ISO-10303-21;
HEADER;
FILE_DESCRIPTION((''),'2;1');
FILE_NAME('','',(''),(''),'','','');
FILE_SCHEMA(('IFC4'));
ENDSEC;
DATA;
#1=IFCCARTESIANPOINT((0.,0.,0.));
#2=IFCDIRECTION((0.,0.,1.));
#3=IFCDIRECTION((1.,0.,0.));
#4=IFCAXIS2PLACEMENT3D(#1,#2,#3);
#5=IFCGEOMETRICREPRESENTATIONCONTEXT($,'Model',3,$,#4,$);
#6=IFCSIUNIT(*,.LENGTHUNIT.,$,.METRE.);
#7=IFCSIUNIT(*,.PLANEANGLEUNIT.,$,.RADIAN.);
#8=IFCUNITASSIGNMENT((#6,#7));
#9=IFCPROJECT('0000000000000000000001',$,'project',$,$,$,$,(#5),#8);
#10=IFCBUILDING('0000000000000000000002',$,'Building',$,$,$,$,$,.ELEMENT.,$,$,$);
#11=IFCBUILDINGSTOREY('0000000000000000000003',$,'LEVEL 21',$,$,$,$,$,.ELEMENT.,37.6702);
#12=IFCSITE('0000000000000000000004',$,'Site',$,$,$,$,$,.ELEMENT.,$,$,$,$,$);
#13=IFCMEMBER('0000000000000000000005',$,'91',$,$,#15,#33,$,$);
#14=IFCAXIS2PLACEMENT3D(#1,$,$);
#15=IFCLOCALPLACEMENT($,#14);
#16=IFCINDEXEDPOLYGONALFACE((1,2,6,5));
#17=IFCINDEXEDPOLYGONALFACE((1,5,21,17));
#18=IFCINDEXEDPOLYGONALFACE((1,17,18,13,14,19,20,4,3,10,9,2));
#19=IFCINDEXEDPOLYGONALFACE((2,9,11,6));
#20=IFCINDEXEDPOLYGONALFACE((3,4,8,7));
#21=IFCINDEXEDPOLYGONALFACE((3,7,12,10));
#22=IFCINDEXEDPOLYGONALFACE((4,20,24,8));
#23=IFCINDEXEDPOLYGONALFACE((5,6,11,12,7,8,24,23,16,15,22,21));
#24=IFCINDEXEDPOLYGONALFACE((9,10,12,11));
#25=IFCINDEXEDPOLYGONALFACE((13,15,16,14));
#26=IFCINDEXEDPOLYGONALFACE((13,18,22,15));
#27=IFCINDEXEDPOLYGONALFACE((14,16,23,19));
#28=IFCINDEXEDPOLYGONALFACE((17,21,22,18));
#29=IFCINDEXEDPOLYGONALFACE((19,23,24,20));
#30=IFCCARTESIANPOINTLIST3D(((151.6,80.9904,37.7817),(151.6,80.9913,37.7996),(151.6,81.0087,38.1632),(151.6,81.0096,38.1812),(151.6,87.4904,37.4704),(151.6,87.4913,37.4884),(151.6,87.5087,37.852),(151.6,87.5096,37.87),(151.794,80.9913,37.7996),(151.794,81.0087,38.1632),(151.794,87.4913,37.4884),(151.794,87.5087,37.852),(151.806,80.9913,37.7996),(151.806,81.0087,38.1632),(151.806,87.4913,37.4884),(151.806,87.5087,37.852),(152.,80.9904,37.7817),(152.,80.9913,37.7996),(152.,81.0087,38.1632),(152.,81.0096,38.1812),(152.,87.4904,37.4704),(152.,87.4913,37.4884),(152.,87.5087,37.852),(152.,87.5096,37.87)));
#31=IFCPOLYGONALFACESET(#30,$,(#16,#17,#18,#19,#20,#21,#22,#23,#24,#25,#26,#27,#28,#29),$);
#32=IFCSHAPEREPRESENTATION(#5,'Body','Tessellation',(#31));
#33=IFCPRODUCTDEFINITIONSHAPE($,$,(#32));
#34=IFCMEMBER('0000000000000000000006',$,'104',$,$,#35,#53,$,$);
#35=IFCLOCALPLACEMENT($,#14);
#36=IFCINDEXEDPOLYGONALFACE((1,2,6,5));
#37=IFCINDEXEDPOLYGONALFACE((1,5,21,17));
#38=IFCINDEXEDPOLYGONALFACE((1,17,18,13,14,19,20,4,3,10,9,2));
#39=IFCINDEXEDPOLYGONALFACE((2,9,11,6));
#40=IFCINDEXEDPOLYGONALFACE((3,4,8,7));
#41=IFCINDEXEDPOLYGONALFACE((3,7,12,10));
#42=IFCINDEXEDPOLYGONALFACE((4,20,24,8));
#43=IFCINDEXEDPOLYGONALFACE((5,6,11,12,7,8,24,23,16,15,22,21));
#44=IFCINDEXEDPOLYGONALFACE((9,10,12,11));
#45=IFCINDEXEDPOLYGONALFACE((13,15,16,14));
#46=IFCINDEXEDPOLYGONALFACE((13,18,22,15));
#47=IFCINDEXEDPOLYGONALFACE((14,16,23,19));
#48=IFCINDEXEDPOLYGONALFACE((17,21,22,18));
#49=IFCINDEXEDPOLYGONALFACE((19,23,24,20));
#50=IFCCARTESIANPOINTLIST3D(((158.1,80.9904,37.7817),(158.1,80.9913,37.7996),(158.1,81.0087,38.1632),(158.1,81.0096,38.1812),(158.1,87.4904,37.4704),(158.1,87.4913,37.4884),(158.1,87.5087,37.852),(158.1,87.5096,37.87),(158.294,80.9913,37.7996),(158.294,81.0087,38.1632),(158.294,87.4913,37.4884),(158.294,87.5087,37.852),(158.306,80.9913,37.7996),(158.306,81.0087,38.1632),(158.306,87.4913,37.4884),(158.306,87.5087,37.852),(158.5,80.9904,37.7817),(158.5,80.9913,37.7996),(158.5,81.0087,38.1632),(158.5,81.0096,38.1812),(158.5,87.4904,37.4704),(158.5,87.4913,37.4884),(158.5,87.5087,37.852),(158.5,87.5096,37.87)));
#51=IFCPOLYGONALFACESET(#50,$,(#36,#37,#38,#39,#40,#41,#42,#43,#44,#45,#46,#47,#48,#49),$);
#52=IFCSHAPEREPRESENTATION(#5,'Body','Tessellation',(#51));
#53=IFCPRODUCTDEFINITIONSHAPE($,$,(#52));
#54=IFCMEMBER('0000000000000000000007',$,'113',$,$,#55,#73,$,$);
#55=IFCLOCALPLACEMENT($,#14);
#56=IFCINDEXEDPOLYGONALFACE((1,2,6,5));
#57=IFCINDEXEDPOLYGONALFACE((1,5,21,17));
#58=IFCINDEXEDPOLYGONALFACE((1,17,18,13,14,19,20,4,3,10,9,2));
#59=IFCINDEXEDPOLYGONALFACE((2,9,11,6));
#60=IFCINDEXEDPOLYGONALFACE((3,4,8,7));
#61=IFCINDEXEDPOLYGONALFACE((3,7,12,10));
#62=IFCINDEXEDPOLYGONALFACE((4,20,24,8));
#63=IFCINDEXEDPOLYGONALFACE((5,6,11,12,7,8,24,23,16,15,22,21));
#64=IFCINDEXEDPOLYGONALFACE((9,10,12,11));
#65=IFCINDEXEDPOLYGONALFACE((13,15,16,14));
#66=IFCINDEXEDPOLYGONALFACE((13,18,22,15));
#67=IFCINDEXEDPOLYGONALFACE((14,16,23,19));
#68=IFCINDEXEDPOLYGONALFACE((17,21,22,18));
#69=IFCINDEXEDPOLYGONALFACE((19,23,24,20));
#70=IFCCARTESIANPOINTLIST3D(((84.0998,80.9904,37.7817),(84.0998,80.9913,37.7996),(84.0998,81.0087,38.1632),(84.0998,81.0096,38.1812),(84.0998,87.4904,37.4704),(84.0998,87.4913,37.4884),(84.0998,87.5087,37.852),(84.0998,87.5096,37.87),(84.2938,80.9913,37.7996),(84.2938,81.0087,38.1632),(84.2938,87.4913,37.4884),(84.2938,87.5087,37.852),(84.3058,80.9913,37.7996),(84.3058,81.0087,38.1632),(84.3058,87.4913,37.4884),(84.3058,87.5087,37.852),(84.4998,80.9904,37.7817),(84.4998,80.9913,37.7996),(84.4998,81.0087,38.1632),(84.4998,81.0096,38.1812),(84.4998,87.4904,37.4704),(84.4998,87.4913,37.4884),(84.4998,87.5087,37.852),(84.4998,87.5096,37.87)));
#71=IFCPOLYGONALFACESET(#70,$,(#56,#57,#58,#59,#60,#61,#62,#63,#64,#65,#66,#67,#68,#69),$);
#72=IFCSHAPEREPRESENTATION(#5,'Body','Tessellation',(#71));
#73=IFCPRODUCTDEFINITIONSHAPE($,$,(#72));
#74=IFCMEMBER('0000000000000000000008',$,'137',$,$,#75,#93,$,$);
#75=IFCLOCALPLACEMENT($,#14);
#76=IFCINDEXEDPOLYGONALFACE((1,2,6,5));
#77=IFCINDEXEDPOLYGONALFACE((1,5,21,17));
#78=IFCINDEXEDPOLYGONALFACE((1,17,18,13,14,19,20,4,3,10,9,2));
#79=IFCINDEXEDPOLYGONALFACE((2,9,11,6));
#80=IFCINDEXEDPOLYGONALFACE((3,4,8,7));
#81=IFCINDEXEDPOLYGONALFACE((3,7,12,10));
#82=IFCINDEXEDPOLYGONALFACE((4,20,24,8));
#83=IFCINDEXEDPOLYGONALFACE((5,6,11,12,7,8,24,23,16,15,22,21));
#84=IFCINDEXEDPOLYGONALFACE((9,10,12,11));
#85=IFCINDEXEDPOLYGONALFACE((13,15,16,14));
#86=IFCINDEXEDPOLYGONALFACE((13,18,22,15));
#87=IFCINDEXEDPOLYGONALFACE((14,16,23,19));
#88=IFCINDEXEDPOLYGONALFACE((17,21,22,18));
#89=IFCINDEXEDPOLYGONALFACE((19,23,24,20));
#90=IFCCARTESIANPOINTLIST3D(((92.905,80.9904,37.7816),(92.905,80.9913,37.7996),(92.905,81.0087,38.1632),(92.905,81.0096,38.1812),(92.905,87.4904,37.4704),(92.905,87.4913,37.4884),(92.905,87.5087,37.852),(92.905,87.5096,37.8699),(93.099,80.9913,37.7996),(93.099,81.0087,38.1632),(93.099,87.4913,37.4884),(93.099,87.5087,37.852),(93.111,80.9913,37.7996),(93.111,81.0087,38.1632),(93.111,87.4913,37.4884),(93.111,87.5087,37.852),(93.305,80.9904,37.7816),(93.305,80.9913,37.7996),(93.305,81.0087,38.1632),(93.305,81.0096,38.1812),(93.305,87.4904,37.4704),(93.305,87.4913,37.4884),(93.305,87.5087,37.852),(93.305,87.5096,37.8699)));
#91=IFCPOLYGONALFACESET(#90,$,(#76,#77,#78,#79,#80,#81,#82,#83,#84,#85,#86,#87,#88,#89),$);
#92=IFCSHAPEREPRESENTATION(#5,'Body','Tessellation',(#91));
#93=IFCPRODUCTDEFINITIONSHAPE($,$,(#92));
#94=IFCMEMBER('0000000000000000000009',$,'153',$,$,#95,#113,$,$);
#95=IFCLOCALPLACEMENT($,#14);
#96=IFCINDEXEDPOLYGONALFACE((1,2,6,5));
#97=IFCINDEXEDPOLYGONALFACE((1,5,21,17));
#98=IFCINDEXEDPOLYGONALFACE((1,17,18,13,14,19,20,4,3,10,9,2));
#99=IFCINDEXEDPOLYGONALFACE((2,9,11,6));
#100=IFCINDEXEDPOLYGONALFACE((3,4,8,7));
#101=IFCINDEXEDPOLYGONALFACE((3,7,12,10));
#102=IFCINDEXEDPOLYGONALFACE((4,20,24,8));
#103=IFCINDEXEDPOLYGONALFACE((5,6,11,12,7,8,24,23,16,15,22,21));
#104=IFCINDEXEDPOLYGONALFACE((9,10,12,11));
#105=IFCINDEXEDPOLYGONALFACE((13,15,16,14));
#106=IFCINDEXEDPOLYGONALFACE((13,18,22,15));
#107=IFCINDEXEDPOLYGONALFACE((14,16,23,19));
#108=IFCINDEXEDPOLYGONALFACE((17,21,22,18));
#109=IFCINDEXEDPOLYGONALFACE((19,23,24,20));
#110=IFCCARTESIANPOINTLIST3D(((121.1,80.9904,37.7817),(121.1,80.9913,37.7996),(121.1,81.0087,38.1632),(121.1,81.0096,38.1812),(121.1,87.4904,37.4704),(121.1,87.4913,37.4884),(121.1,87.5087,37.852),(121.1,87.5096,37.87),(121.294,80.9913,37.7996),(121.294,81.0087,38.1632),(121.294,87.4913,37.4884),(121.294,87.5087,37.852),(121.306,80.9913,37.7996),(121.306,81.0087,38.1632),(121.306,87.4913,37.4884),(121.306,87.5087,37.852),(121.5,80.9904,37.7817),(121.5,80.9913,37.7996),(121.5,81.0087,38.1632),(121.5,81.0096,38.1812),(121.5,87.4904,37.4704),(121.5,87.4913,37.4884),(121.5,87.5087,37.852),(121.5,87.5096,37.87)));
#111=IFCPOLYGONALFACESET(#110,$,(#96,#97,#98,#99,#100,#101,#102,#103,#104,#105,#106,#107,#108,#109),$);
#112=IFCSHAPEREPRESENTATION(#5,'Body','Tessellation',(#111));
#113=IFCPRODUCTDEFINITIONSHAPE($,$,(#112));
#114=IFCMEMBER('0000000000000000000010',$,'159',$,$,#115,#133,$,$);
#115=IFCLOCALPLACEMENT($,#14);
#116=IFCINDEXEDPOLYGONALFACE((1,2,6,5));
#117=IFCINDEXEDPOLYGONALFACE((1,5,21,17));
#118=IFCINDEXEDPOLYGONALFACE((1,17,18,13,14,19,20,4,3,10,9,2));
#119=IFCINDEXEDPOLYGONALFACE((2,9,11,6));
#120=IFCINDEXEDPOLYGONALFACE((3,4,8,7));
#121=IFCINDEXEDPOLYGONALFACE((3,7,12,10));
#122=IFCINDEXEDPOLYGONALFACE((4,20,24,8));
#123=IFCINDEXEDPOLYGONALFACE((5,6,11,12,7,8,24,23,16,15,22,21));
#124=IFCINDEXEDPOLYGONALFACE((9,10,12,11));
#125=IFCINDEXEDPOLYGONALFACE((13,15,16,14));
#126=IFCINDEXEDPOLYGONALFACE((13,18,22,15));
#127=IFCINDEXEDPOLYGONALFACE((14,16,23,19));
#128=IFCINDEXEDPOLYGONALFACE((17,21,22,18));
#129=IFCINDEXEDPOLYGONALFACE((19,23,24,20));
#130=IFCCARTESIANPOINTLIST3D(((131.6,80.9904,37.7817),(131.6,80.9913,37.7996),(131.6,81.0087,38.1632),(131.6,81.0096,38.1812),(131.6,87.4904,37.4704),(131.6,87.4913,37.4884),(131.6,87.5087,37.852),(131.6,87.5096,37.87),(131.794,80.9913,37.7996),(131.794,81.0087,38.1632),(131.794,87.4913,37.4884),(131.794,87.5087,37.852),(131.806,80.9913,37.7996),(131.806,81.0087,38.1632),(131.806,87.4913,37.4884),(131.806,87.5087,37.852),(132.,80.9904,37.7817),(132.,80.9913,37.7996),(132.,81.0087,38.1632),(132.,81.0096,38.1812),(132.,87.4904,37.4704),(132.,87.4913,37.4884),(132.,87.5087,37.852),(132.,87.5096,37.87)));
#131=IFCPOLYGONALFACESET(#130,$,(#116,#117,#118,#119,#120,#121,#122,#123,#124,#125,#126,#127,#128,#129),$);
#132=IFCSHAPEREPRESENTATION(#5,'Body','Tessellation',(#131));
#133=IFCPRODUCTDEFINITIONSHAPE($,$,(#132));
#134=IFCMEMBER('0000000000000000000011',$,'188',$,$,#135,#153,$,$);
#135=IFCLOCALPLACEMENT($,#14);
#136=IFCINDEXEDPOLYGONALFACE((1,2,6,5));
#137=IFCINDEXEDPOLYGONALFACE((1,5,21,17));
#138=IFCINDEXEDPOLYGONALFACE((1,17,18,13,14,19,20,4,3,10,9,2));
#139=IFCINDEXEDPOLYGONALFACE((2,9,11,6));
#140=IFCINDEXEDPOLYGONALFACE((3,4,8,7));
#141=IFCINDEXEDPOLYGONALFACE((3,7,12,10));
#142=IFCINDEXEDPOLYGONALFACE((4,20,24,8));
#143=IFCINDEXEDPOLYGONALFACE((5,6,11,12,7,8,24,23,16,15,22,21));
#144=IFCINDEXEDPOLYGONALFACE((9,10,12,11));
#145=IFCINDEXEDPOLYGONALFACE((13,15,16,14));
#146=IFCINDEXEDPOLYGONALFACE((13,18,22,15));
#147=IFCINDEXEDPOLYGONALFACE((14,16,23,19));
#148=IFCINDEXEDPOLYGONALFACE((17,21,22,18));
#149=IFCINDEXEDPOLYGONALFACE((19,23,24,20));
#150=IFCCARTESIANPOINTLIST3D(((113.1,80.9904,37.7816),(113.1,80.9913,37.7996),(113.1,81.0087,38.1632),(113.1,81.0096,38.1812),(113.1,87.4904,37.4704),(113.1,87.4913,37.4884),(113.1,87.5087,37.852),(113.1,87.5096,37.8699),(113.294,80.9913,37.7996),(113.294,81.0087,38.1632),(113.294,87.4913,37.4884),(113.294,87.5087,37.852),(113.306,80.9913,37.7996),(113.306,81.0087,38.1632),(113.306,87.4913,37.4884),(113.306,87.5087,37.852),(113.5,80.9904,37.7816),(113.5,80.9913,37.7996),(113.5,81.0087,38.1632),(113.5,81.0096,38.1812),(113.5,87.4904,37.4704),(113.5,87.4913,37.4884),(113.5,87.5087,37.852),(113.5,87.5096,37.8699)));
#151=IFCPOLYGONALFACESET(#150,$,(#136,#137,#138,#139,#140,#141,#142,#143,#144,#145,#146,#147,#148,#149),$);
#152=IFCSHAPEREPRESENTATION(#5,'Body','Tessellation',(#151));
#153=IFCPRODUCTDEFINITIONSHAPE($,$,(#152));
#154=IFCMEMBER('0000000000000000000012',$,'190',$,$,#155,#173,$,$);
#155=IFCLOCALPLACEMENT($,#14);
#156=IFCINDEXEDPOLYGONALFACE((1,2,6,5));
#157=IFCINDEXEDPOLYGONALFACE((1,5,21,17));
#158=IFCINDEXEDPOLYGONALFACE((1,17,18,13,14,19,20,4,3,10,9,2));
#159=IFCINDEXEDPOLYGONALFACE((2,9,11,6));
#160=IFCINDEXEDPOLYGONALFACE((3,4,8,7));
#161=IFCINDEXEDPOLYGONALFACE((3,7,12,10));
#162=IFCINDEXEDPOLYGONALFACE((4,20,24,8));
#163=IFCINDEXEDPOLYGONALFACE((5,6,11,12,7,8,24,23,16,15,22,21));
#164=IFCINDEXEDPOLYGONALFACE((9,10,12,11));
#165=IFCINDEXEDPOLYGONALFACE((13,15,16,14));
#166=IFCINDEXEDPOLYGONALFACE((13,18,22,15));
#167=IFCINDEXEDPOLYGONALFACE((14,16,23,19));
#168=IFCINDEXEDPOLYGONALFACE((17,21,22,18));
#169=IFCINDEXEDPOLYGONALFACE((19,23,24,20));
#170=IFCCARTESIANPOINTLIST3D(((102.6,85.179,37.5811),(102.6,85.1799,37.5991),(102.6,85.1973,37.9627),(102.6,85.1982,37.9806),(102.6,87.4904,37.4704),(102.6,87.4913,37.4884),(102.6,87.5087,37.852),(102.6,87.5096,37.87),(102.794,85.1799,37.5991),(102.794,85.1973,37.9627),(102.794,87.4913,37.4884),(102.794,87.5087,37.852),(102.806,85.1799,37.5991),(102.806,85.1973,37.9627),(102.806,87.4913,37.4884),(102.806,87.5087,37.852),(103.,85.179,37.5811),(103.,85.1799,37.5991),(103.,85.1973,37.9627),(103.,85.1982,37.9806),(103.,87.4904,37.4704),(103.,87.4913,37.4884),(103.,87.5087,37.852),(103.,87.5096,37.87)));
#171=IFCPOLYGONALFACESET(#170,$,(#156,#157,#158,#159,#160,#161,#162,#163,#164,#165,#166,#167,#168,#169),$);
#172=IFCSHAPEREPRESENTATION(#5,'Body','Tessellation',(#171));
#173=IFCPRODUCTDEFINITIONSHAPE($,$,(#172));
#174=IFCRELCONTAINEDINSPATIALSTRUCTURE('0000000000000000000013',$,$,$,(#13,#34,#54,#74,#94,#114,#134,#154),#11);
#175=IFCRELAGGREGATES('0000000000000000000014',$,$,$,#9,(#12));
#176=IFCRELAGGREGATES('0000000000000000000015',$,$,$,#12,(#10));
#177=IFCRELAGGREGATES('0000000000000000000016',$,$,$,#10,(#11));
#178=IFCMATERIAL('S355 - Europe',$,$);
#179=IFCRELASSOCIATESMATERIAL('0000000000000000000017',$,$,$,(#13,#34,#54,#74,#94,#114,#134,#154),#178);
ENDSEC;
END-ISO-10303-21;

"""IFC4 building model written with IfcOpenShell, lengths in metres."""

from ifc_helpers import new_model, si_unit, frame, origin_with_axes, origin_2d_with_axis, place, context, project, spatial, i_section, extrude, material, material_profile, profile_set, profile_usage, element, save


model = new_model("IFC4")

# Units and contexts
model_context = context("Model", 3, world=origin_with_axes())
ifc_project = project(units=[si_unit("LENGTHUNIT", "METRE"), si_unit("PLANEANGLEUNIT", "RADIAN")], contexts=[model_context])

# Site, building, storey
site = spatial("IfcSite", under=ifc_project, Name="Site", CompositionType="ELEMENT")
building = spatial("IfcBuilding", under=site, Name="Building", CompositionType="ELEMENT")
storey = spatial("IfcBuildingStorey", under=building, Name="LEVEL 21", CompositionType="ELEMENT", Elevation=37.6702)

# Shared definitions
ifc_material = material(Name="S355 - Europe")

# Members
ifc_material_profile_1 = material_profile(ifc_material, i_section(OverallWidth=0.4, OverallDepth=0.4, WebThickness=0.012, FlangeThickness=0.018, at=origin_2d_with_axis()))
ifc_profile_set_1 = profile_set([ifc_material_profile_1])
ifc_profile_usage_1 = profile_usage(ifc_profile_set_1, cardinal=10)
member_1_placement = place(None, frame((151.8, 87.5, 37.6702), z_axis=(0.0, -0.998856, 0.047828), x_axis=(1.0, 0.0, 0.0)))
element("IfcMember", 1, at=member_1_placement, inside=storey, material=ifc_profile_usage_1, Name="91", context=model_context, shape_type="SweptSolid", body=[
    extrude(i_section(OverallWidth=0.4, OverallDepth=0.4, WebThickness=0.012, FlangeThickness=0.018, at=origin_2d_with_axis()), origin_with_axes(), (0.0, 0.0, 1.0), 6.5074),
])
ifc_material_profile_2 = material_profile(ifc_material, i_section(OverallWidth=0.4, OverallDepth=0.4, WebThickness=0.012, FlangeThickness=0.018, at=origin_2d_with_axis()))
ifc_profile_set_2 = profile_set([ifc_material_profile_2])
ifc_profile_usage_2 = profile_usage(ifc_profile_set_2, cardinal=10)
member_2_placement = place(None, frame((158.3, 87.5, 37.6702), z_axis=(0.0, -0.998856, 0.047828), x_axis=(1.0, 0.0, 0.0)))
element("IfcMember", 2, at=member_2_placement, inside=storey, material=ifc_profile_usage_2, Name="104", context=model_context, shape_type="SweptSolid", body=[
    extrude(i_section(OverallWidth=0.4, OverallDepth=0.4, WebThickness=0.012, FlangeThickness=0.018, at=origin_2d_with_axis()), origin_with_axes(), (0.0, 0.0, 1.0), 6.5074),
])
ifc_material_profile_3 = material_profile(ifc_material, i_section(OverallWidth=0.4, OverallDepth=0.4, WebThickness=0.012, FlangeThickness=0.018, at=origin_2d_with_axis()))
ifc_profile_set_3 = profile_set([ifc_material_profile_3])
ifc_profile_usage_3 = profile_usage(ifc_profile_set_3, cardinal=10)
member_3_placement = place(None, frame((84.2998, 87.5, 37.6702), z_axis=(0.0, -0.998856, 0.047828), x_axis=(1.0, 0.0, 0.0)))
element("IfcMember", 3, at=member_3_placement, inside=storey, material=ifc_profile_usage_3, Name="113", context=model_context, shape_type="SweptSolid", body=[
    extrude(i_section(OverallWidth=0.4, OverallDepth=0.4, WebThickness=0.012, FlangeThickness=0.018, at=origin_2d_with_axis()), origin_with_axes(), (0.0, 0.0, 1.0), 6.5074),
])
ifc_material_profile_4 = material_profile(ifc_material, i_section(OverallWidth=0.4, OverallDepth=0.4, WebThickness=0.012, FlangeThickness=0.018, at=origin_2d_with_axis()))
ifc_profile_set_4 = profile_set([ifc_material_profile_4])
ifc_profile_usage_4 = profile_usage(ifc_profile_set_4, cardinal=10)
member_4_placement = place(None, frame((93.105, 81.0, 37.9814), z_axis=(0.0, 0.998856, -0.047828), x_axis=(-1.0, 0.0, 0.0)))
element("IfcMember", 4, at=member_4_placement, inside=storey, material=ifc_profile_usage_4, Name="137", context=model_context, shape_type="SweptSolid", body=[
    extrude(i_section(OverallWidth=0.4, OverallDepth=0.4, WebThickness=0.012, FlangeThickness=0.018, at=origin_2d_with_axis()), origin_with_axes(), (0.0, 0.0, 1.0), 6.5074),
])
ifc_material_profile_5 = material_profile(ifc_material, i_section(OverallWidth=0.4, OverallDepth=0.4, WebThickness=0.012, FlangeThickness=0.018, at=origin_2d_with_axis()))
ifc_profile_set_5 = profile_set([ifc_material_profile_5])
ifc_profile_usage_5 = profile_usage(ifc_profile_set_5, cardinal=10)
member_5_placement = place(None, frame((121.3, 87.5, 37.6702), z_axis=(0.0, -0.998856, 0.047828), x_axis=(1.0, 0.0, 0.0)))
element("IfcMember", 5, at=member_5_placement, inside=storey, material=ifc_profile_usage_5, Name="153", context=model_context, shape_type="SweptSolid", body=[
    extrude(i_section(OverallWidth=0.4, OverallDepth=0.4, WebThickness=0.012, FlangeThickness=0.018, at=origin_2d_with_axis()), origin_with_axes(), (0.0, 0.0, 1.0), 6.5074),
])
ifc_material_profile_6 = material_profile(ifc_material, i_section(OverallWidth=0.4, OverallDepth=0.4, WebThickness=0.012, FlangeThickness=0.018, at=origin_2d_with_axis()))
ifc_profile_set_6 = profile_set([ifc_material_profile_6])
ifc_profile_usage_6 = profile_usage(ifc_profile_set_6, cardinal=10)
member_6_placement = place(None, frame((131.8, 87.5, 37.6702), z_axis=(0.0, -0.998856, 0.047828), x_axis=(1.0, 0.0, 0.0)))
element("IfcMember", 6, at=member_6_placement, inside=storey, material=ifc_profile_usage_6, Name="159", context=model_context, shape_type="SweptSolid", body=[
    extrude(i_section(OverallWidth=0.4, OverallDepth=0.4, WebThickness=0.012, FlangeThickness=0.018, at=origin_2d_with_axis()), origin_with_axes(), (0.0, 0.0, 1.0), 6.5074),
])
ifc_material_profile_7 = material_profile(ifc_material, i_section(OverallWidth=0.4, OverallDepth=0.4, WebThickness=0.012, FlangeThickness=0.018, at=origin_2d_with_axis()))
ifc_profile_set_7 = profile_set([ifc_material_profile_7])
ifc_profile_usage_7 = profile_usage(ifc_profile_set_7, cardinal=10)
member_7_placement = place(None, frame((113.3, 81.0, 37.9814), z_axis=(0.0, 0.998856, -0.047828), x_axis=(-1.0, 0.0, 0.0)))
element("IfcMember", 7, at=member_7_placement, inside=storey, material=ifc_profile_usage_7, Name="188", context=model_context, shape_type="SweptSolid", body=[
    extrude(i_section(OverallWidth=0.4, OverallDepth=0.4, WebThickness=0.012, FlangeThickness=0.018, at=origin_2d_with_axis()), origin_with_axes(), (0.0, 0.0, 1.0), 6.5074),
])
ifc_material_profile_8 = material_profile(ifc_material, i_section(OverallWidth=0.4, OverallDepth=0.4, WebThickness=0.012, FlangeThickness=0.018, at=origin_2d_with_axis()))
ifc_profile_set_8 = profile_set([ifc_material_profile_8])
ifc_profile_usage_8 = profile_usage(ifc_profile_set_8, cardinal=10)
member_8_placement = place(None, frame((102.8, 87.5, 37.6702), z_axis=(0.0, -0.998856, 0.047828), x_axis=(1.0, 0.0, 0.0)))
element("IfcMember", 8, at=member_8_placement, inside=storey, material=ifc_profile_usage_8, Name="190", context=model_context, shape_type="SweptSolid", body=[
    extrude(i_section(OverallWidth=0.4, OverallDepth=0.4, WebThickness=0.012, FlangeThickness=0.018, at=origin_2d_with_axis()), origin_with_axes(), (0.0, 0.0, 1.0), 2.314),
])

save(model, "model.ifc")
